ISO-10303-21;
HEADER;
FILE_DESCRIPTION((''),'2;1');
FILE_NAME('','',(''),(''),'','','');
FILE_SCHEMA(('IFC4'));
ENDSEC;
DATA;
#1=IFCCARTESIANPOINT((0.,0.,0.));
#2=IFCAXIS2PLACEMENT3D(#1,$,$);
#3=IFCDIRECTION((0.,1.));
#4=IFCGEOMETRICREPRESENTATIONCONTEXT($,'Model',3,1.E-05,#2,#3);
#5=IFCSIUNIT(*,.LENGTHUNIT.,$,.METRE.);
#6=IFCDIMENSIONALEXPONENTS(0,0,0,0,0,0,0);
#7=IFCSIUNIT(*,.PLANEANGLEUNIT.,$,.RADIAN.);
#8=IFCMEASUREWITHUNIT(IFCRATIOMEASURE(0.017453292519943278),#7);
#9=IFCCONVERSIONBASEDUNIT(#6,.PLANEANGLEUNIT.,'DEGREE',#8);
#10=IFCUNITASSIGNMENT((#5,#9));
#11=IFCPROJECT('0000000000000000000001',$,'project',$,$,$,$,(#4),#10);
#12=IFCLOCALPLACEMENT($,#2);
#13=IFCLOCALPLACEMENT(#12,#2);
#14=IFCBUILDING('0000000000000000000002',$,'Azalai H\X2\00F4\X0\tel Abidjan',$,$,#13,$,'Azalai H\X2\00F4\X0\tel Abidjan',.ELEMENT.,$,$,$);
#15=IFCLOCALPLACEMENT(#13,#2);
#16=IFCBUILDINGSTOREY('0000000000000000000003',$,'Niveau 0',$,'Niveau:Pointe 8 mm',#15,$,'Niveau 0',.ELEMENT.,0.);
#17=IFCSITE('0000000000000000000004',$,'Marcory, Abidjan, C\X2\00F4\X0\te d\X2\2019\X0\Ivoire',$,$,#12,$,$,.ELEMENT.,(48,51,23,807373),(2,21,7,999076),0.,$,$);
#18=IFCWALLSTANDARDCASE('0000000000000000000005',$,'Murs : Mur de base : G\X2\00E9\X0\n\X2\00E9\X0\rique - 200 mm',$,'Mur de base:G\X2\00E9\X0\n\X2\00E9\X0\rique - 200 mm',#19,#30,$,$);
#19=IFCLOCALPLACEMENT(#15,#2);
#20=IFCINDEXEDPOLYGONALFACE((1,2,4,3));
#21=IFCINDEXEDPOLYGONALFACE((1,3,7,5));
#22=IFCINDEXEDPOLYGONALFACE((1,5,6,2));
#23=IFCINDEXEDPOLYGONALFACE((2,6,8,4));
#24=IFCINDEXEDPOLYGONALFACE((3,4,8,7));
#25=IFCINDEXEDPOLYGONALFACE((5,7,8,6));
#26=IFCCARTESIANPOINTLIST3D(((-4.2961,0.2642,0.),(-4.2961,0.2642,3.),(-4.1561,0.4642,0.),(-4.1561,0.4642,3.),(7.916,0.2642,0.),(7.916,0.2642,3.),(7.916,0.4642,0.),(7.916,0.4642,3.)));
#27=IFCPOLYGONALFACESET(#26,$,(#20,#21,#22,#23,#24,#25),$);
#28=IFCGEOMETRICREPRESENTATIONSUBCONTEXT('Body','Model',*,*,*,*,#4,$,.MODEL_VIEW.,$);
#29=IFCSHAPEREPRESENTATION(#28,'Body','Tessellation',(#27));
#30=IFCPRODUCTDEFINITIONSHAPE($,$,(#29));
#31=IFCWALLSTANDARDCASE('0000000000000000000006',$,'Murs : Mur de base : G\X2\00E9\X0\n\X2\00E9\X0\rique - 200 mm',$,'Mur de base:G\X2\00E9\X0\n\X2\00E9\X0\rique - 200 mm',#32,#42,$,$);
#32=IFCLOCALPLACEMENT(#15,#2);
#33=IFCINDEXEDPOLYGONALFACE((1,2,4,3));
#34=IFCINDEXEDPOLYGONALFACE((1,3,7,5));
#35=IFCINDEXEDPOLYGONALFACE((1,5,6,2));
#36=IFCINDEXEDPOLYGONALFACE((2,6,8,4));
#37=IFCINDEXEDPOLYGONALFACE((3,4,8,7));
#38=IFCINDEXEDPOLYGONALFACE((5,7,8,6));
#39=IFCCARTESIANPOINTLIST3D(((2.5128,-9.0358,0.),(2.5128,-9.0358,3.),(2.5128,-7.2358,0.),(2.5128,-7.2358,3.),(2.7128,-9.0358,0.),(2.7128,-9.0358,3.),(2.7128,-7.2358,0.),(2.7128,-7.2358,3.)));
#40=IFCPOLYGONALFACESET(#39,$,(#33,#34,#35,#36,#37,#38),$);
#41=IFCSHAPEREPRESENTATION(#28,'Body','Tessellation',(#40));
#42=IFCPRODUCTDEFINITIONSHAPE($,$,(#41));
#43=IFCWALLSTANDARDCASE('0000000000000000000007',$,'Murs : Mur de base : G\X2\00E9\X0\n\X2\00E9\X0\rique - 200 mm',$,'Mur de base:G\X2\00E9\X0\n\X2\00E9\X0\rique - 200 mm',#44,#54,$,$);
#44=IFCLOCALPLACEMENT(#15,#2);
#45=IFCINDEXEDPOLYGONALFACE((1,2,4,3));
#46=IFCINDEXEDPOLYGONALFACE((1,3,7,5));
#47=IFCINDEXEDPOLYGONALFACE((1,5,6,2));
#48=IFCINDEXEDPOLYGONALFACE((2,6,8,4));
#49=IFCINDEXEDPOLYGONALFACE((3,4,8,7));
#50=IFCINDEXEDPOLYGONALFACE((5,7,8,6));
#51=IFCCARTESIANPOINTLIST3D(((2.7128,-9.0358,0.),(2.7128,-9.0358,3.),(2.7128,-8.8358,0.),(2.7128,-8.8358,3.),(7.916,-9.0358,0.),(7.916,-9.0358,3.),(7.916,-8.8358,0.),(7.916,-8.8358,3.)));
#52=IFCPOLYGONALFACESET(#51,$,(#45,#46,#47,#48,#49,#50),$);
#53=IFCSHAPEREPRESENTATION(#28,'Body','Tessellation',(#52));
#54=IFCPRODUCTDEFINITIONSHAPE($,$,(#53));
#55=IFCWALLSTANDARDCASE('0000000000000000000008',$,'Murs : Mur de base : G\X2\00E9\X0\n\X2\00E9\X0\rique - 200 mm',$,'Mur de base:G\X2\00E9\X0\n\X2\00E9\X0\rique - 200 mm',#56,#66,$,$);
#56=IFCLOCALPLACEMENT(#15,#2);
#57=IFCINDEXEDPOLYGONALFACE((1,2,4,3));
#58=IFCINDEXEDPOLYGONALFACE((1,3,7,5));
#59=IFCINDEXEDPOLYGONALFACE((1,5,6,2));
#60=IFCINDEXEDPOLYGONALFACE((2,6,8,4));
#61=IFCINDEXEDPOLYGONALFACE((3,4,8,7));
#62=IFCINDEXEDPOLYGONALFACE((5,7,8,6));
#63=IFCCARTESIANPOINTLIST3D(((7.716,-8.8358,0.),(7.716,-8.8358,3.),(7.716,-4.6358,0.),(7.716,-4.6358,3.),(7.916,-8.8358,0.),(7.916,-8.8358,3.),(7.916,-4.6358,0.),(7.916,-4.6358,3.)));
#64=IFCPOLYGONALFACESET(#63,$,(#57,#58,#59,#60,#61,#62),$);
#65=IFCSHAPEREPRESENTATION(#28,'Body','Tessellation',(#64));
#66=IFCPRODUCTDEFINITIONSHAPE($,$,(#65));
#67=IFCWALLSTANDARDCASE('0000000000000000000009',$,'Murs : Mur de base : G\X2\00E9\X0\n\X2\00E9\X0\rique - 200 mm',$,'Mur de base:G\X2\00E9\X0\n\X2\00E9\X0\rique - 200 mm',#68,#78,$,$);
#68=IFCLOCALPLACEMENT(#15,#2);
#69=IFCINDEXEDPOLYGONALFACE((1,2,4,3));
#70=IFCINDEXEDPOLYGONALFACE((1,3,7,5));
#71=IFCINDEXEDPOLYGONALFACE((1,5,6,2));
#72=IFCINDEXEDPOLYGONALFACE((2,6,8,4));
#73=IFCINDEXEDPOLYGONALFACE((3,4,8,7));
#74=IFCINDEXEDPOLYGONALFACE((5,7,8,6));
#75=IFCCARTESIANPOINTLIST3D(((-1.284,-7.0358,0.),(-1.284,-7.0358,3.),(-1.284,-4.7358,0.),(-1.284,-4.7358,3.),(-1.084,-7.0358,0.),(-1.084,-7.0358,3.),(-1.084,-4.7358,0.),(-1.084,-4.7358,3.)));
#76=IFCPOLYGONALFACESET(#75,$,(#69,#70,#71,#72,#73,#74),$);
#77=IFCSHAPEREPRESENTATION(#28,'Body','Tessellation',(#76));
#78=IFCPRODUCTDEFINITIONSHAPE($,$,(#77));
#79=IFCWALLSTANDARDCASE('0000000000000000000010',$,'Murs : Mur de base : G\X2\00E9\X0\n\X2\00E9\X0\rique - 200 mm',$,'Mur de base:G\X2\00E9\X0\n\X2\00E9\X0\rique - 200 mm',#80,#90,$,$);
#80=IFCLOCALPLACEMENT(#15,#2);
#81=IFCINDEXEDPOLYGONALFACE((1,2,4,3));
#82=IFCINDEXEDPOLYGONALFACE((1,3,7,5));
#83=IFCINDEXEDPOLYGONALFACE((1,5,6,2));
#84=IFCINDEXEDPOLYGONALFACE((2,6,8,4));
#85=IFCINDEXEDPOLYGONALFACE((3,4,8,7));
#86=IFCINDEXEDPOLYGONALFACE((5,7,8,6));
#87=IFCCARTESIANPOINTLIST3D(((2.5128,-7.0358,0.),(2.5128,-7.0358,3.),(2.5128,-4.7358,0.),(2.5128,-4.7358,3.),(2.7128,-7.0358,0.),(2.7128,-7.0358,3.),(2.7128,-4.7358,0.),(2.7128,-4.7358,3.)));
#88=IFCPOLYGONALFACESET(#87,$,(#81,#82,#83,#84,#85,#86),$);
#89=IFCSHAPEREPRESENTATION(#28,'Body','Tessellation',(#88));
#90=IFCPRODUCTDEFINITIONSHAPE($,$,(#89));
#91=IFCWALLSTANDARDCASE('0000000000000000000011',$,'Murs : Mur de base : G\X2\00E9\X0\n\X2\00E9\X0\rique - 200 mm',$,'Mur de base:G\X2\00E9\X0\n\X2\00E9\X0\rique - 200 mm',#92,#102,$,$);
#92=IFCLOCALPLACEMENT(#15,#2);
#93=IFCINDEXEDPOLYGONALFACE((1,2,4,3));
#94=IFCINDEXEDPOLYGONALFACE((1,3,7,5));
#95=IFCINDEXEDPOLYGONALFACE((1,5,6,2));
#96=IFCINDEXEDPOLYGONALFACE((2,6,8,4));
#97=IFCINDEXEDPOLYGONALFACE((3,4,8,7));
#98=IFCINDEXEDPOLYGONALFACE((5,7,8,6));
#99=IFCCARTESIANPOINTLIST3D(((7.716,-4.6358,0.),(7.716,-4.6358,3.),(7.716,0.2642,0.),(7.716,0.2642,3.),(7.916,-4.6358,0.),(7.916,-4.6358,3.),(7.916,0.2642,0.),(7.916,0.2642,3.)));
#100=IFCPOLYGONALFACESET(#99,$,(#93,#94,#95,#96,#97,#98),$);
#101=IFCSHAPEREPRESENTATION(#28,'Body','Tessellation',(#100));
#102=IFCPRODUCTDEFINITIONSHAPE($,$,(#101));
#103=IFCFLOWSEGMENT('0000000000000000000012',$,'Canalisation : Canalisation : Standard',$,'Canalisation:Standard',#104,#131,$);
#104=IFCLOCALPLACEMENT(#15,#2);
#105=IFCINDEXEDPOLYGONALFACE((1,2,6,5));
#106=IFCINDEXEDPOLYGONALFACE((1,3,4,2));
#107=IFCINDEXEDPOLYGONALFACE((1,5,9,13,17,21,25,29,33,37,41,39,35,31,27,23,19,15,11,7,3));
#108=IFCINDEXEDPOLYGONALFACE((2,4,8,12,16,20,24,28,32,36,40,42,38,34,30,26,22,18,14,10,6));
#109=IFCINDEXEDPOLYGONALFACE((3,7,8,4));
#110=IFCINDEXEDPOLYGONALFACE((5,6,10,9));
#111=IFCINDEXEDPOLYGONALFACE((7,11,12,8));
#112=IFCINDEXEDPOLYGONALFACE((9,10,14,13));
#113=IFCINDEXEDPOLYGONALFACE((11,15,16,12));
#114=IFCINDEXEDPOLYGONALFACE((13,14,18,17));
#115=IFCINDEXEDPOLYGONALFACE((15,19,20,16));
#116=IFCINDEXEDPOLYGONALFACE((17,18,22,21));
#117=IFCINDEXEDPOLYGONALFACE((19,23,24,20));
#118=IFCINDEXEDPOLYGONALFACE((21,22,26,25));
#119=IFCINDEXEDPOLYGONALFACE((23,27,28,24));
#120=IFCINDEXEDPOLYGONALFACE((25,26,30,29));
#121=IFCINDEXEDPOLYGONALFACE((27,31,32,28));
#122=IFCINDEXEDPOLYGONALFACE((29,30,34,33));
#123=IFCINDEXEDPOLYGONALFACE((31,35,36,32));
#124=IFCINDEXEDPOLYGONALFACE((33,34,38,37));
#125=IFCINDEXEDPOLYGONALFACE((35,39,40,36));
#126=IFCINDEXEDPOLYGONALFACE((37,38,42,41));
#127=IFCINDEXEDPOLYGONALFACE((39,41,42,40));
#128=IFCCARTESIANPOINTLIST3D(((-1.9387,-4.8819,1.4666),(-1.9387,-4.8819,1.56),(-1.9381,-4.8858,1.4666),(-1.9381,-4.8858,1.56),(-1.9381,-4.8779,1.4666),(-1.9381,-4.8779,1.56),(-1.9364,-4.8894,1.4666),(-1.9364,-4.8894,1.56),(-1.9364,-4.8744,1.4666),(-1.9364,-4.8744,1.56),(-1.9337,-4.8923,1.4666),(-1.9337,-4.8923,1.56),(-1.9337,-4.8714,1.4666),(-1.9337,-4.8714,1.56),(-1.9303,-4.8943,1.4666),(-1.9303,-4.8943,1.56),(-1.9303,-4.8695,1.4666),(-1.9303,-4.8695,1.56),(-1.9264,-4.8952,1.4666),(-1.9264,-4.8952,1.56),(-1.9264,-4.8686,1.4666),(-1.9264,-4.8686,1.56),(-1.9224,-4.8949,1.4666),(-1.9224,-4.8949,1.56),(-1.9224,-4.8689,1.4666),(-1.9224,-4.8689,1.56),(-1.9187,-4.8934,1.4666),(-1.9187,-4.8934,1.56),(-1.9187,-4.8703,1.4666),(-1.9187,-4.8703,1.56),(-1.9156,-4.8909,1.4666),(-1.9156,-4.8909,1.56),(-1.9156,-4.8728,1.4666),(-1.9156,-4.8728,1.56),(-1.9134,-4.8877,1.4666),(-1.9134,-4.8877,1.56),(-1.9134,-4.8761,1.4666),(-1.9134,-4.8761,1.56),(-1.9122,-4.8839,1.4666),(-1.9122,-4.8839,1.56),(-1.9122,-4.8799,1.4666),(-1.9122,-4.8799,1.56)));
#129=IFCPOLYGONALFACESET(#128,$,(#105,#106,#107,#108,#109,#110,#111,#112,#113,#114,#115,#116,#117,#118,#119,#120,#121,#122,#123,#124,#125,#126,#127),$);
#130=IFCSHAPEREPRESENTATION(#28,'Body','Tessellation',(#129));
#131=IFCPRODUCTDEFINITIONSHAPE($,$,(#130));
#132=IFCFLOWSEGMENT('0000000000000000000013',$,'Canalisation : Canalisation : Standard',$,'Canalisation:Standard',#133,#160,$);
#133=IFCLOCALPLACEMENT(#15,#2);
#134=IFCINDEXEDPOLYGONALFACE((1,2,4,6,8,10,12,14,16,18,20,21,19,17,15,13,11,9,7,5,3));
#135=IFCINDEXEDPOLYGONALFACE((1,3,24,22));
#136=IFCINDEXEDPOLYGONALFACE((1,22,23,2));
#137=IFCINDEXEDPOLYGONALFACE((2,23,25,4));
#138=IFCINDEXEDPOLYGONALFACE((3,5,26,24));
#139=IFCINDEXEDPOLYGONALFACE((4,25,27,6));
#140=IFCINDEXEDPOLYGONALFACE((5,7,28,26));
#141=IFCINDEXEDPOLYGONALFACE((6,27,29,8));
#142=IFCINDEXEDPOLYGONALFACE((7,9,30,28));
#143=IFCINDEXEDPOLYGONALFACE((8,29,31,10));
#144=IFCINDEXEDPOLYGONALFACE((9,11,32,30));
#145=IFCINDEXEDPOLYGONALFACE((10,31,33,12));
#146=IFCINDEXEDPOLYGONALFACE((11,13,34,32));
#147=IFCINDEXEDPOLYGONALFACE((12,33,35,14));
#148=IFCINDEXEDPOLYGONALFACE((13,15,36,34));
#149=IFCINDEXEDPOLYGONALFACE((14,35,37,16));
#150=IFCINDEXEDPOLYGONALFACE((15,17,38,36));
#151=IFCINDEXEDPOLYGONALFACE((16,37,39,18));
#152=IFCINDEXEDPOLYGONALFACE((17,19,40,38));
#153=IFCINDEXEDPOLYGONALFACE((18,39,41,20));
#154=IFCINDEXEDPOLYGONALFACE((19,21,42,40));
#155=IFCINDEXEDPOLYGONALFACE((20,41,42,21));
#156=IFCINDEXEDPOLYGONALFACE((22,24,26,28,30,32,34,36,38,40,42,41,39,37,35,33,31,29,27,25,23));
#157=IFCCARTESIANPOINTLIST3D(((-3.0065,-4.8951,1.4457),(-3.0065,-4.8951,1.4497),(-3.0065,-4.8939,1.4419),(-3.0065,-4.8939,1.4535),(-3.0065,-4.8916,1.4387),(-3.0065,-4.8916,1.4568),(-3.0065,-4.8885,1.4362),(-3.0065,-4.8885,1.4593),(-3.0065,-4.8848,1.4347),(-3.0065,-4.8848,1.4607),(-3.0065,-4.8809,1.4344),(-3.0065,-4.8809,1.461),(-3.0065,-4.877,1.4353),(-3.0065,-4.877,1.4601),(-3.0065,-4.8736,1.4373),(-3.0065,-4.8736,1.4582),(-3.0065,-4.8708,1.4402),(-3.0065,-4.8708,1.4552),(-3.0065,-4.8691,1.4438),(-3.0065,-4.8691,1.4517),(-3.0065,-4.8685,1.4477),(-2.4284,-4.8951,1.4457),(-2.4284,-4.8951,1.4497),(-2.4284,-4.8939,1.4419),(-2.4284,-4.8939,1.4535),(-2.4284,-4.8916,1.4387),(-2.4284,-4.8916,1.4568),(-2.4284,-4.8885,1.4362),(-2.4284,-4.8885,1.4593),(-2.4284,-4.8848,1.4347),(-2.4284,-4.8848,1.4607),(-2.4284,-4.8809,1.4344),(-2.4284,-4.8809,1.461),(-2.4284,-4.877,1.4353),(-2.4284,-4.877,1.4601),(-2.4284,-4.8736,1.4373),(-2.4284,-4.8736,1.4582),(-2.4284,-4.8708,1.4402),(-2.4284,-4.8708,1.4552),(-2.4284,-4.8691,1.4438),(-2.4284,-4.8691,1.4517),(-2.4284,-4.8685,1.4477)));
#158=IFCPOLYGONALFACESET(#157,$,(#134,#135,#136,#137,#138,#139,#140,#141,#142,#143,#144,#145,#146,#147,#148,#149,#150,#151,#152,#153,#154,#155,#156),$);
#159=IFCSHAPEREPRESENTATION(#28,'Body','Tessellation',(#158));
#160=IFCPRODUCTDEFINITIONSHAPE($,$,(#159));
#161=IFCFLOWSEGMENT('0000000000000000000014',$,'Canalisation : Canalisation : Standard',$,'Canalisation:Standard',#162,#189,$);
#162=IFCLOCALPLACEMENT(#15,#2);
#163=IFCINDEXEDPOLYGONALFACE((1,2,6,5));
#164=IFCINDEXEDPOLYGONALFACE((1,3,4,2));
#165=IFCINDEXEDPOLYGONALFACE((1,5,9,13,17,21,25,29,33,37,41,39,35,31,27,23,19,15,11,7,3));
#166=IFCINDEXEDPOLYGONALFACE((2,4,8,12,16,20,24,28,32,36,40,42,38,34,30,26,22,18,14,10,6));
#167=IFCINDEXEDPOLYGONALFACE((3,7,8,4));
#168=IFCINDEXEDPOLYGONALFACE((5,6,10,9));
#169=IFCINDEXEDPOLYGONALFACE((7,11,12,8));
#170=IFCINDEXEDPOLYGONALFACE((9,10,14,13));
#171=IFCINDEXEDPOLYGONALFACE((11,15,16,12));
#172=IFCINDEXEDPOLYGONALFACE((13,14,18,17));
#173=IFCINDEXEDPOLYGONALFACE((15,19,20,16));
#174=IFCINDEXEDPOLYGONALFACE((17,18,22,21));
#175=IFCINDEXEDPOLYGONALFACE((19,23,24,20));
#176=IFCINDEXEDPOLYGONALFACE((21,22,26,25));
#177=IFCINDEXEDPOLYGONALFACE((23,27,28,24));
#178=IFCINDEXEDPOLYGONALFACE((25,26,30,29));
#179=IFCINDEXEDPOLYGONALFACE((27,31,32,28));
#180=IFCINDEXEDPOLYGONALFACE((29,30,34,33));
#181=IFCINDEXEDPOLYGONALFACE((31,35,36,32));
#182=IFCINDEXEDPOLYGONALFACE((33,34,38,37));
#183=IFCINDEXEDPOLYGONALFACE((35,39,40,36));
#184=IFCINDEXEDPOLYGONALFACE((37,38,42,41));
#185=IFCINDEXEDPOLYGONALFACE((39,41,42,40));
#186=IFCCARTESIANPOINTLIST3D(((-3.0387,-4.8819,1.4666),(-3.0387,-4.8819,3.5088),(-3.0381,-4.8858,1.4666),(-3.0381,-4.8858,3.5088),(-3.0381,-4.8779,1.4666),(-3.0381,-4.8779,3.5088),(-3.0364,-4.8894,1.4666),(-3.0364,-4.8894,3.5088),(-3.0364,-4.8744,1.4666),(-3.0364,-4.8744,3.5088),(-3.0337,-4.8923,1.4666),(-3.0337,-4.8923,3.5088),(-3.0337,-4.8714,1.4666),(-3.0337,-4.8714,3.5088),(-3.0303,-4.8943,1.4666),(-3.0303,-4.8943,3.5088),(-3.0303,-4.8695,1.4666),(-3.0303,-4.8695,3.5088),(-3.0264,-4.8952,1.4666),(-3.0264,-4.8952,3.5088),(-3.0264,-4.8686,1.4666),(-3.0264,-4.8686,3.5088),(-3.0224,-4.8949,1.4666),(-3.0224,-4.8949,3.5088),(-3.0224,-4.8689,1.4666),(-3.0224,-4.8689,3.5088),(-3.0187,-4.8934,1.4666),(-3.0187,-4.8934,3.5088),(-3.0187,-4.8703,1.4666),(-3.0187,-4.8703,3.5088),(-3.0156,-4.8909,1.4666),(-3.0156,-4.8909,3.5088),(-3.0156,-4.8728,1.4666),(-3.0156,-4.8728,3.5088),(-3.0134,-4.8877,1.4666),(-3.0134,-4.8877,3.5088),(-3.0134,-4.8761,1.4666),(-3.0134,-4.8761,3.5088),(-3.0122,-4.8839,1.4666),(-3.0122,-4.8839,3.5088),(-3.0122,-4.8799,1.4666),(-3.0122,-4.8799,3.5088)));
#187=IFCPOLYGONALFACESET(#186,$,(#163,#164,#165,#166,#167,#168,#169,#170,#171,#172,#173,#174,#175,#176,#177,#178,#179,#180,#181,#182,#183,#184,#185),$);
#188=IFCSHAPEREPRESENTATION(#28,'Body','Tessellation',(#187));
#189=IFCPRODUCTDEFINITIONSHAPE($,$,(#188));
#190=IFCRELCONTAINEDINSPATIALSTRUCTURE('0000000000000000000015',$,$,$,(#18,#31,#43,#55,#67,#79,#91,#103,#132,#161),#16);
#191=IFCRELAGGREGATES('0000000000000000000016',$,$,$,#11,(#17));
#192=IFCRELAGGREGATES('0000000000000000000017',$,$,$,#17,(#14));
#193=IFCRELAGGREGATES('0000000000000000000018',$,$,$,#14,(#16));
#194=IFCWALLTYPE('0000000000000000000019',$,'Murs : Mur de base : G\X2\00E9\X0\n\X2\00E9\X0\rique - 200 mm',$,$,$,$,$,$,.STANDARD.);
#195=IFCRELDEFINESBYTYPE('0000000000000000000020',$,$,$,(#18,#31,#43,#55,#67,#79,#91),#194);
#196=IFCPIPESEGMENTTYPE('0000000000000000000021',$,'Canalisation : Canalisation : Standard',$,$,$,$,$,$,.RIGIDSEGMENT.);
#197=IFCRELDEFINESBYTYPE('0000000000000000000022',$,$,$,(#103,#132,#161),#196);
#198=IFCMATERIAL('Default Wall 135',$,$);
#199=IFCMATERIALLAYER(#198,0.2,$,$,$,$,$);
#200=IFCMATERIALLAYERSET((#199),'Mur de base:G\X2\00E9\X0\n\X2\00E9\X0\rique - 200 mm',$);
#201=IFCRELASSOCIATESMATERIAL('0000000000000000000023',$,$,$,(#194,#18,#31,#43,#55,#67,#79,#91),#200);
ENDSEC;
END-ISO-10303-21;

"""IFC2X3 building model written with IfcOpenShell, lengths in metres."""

from ifc_helpers import new_model, entity, si_unit, converted_unit, direction, frame, frame_2d, origin, origin_2d_with_axis, place, context, subcontext, project, spatial, polyline, rectangle, circle, outline, extrude, clip, halfspace, material, layer, layer_set, layer_usage, type_object, element, save


model = new_model("IFC2X3")

# Units and contexts
model_context = context("Model", 3, precision=1e-05, world=origin(), true_north=direction((0.0, 1.0)))
body_context = subcontext(model_context, "Body", "Model", "MODEL_VIEW")
ifc_project = project(units=[si_unit("LENGTHUNIT", "METRE"), converted_unit("PLANEANGLEUNIT", "DEGREE", entity("IfcRatioMeasure", 0.017453292519943278), si_unit("PLANEANGLEUNIT", "RADIAN"), dimensions=[0, 0, 0, 0, 0, 0, 0])], contexts=[model_context])

# Site, building, storey
site_placement = place(None, origin())
site = spatial("IfcSite", under=ifc_project, at=site_placement, Name="Marcory, Abidjan, Côte d’Ivoire", CompositionType="ELEMENT", RefLatitude=(48, 51, 23, 807373), RefLongitude=(2, 21, 7, 999076), RefElevation=0.0)
building_placement = place(site_placement, origin())
building = spatial("IfcBuilding", under=site, at=building_placement, Name="Azalai Hôtel Abidjan", LongName="Azalai Hôtel Abidjan", CompositionType="ELEMENT")
storey_placement = place(building_placement, origin())
storey = spatial("IfcBuildingStorey", under=building, at=storey_placement, Name="Niveau 0", ObjectType="Niveau:Pointe 8 mm", LongName="Niveau 0", CompositionType="ELEMENT", Elevation=0.0)

# Walls
ifc_material_1 = material(Name="Default Wall 135")
ifc_layer_1 = layer(ifc_material_1, 0.2)
ifc_layer_set_1 = layer_set([ifc_layer_1], Name="Mur de base:Générique - 200 mm")
ifc_layer_usage_1 = layer_usage(ifc_layer_set_1, "AXIS2", "NEGATIVE", 0.1)
wall_type = type_object("IfcWallType", Name="Murs : Mur de base : Générique - 200 mm", PredefinedType="STANDARD", material=ifc_layer_set_1)
wall_1_placement = place(storey_placement, frame((7.916, 0.3642, 0.0), z_axis=(0.0, 0.0, 1.0), x_axis=(-1.0, 0.0, 0.0)))
element("IfcWallStandardCase", 1, at=wall_1_placement, inside=storey, type_object=wall_type, material=ifc_layer_usage_1, Name="Murs : Mur de base : Générique - 200 mm", ObjectType="Mur de base:Générique - 200 mm", context=body_context, shape_type="Clipping", body=[
    clip(extrude(outline(polyline([(12.0721, -0.1), (12.2121, 0.1), (11.9679, 0.1), (0.2, 0.1), (0.0, 0.1), (0.0, -0.1), (12.0721, -0.1)])), origin(), (0.0, 0.0, 1.0), 3.0), halfspace(origin(), True)),
])
wall_2_placement = place(storey_placement, frame((2.6128, -7.2358, 0.0), z_axis=(0.0, 0.0, 1.0), x_axis=(0.0, -1.0, 0.0)))
element("IfcWallStandardCase", 2, at=wall_2_placement, inside=storey, type_object=wall_type, material=ifc_layer_usage_1, Name="Murs : Mur de base : Générique - 200 mm", ObjectType="Mur de base:Générique - 200 mm", context=body_context, shape_type="Clipping", body=[
    clip(extrude(rectangle(XDim=1.8, YDim=0.2, at=frame_2d((0.9, 0.0), x_axis=(-1.0, 0.0))), origin(), (0.0, 0.0, 1.0), 3.0), halfspace(origin(), True)),
])
wall_3_placement = place(storey_placement, frame((2.7128, -8.9358, 0.0)))
element("IfcWallStandardCase", 3, at=wall_3_placement, inside=storey, type_object=wall_type, material=ifc_layer_usage_1, Name="Murs : Mur de base : Générique - 200 mm", ObjectType="Mur de base:Générique - 200 mm", context=body_context, shape_type="Clipping", body=[
    clip(extrude(rectangle(XDim=5.2032, YDim=0.2, at=frame_2d((2.6016, 0.0), x_axis=(-1.0, 0.0))), origin(), (0.0, 0.0, 1.0), 3.0), halfspace(origin(), True)),
])
wall_4_placement = place(storey_placement, frame((7.816, -8.8358, 0.0), z_axis=(0.0, 0.0, 1.0), x_axis=(0.0, 1.0, 0.0)))
element("IfcWallStandardCase", 4, at=wall_4_placement, inside=storey, type_object=wall_type, material=ifc_layer_usage_1, Name="Murs : Mur de base : Générique - 200 mm", ObjectType="Mur de base:Générique - 200 mm", context=body_context, shape_type="Clipping", body=[
    clip(extrude(rectangle(XDim=4.2, YDim=0.2, at=frame_2d((2.1, 0.0), x_axis=(-1.0, 0.0))), origin(), (0.0, 0.0, 1.0), 3.0), halfspace(origin(), True)),
])
wall_5_placement = place(storey_placement, frame((-1.184, -4.7358, 0.0), z_axis=(0.0, 0.0, 1.0), x_axis=(0.0, -1.0, 0.0)))
element("IfcWallStandardCase", 5, at=wall_5_placement, inside=storey, type_object=wall_type, material=ifc_layer_usage_1, Name="Murs : Mur de base : Générique - 200 mm", ObjectType="Mur de base:Générique - 200 mm", context=body_context, shape_type="SweptSolid", body=[
    extrude(rectangle(XDim=2.3, YDim=0.2, at=frame_2d((1.15, 0.0), x_axis=(-1.0, 0.0))), origin(), (0.0, 0.0, 1.0), 3.0),
])
wall_6_placement = place(storey_placement, frame((2.6128, -4.7358, 0.0), z_axis=(0.0, 0.0, 1.0), x_axis=(0.0, -1.0, 0.0)))
element("IfcWallStandardCase", 6, at=wall_6_placement, inside=storey, type_object=wall_type, material=ifc_layer_usage_1, Name="Murs : Mur de base : Générique - 200 mm", ObjectType="Mur de base:Générique - 200 mm", context=body_context, shape_type="SweptSolid", body=[
    extrude(rectangle(XDim=2.3, YDim=0.2, at=frame_2d((1.15, 0.0), x_axis=(-1.0, 0.0))), origin(), (0.0, 0.0, 1.0), 3.0),
])
wall_7_placement = place(storey_placement, frame((7.816, -4.6358, 0.0), z_axis=(0.0, 0.0, 1.0), x_axis=(0.0, 1.0, 0.0)))
element("IfcWallStandardCase", 7, at=wall_7_placement, inside=storey, type_object=wall_type, material=ifc_layer_usage_1, Name="Murs : Mur de base : Générique - 200 mm", ObjectType="Mur de base:Générique - 200 mm", context=body_context, shape_type="Clipping", body=[
    clip(extrude(rectangle(XDim=4.9, YDim=0.2, at=frame_2d((2.45, 0.0), x_axis=(-1.0, 0.0))), origin(), (0.0, 0.0, 1.0), 3.0), halfspace(origin(), True)),
])

# Flow segments
pipe_segment_type = type_object("IfcPipeSegmentType", Name="Canalisation : Canalisation : Standard", PredefinedType="RIGIDSEGMENT")
flow_segment_1_placement = place(storey_placement, origin())
element("IfcFlowSegment", 8, at=flow_segment_1_placement, inside=storey, type_object=pipe_segment_type, Name="Canalisation : Canalisation : Standard", ObjectType="Canalisation:Standard", context=body_context, shape_type="SweptSolid", body=[
    extrude(circle(Radius=0.0133, at=origin_2d_with_axis()), frame((-1.9254, -4.8819, 1.4666), z_axis=(0.0, 0.0, 1.0), x_axis=(-1.0, 0.0, 0.0)), (0.0, 0.0, 1.0), 0.0934),
])
flow_segment_2_placement = place(storey_placement, origin())
element("IfcFlowSegment", 9, at=flow_segment_2_placement, inside=storey, type_object=pipe_segment_type, Name="Canalisation : Canalisation : Standard", ObjectType="Canalisation:Standard", context=body_context, shape_type="SweptSolid", body=[
    extrude(circle(Radius=0.0133, at=frame_2d((0.0, 0.0), x_axis=(1.0, 0.0))), frame((-3.0065, -4.8819, 1.4477), z_axis=(1.0, 0.0, 0.0), x_axis=(0.0, 1.0, 0.0)), (0.0, 0.0, 1.0), 0.5781),
])
flow_segment_3_placement = place(storey_placement, origin())
element("IfcFlowSegment", 10, at=flow_segment_3_placement, inside=storey, type_object=pipe_segment_type, Name="Canalisation : Canalisation : Standard", ObjectType="Canalisation:Standard", context=body_context, shape_type="SweptSolid", body=[
    extrude(circle(Radius=0.0133, at=origin_2d_with_axis()), frame((-3.0254, -4.8819, 1.4666), z_axis=(0.0, 0.0, 1.0), x_axis=(-1.0, 0.0, 0.0)), (0.0, 0.0, 1.0), 2.0422),
])

save(model, "model.ifc")
